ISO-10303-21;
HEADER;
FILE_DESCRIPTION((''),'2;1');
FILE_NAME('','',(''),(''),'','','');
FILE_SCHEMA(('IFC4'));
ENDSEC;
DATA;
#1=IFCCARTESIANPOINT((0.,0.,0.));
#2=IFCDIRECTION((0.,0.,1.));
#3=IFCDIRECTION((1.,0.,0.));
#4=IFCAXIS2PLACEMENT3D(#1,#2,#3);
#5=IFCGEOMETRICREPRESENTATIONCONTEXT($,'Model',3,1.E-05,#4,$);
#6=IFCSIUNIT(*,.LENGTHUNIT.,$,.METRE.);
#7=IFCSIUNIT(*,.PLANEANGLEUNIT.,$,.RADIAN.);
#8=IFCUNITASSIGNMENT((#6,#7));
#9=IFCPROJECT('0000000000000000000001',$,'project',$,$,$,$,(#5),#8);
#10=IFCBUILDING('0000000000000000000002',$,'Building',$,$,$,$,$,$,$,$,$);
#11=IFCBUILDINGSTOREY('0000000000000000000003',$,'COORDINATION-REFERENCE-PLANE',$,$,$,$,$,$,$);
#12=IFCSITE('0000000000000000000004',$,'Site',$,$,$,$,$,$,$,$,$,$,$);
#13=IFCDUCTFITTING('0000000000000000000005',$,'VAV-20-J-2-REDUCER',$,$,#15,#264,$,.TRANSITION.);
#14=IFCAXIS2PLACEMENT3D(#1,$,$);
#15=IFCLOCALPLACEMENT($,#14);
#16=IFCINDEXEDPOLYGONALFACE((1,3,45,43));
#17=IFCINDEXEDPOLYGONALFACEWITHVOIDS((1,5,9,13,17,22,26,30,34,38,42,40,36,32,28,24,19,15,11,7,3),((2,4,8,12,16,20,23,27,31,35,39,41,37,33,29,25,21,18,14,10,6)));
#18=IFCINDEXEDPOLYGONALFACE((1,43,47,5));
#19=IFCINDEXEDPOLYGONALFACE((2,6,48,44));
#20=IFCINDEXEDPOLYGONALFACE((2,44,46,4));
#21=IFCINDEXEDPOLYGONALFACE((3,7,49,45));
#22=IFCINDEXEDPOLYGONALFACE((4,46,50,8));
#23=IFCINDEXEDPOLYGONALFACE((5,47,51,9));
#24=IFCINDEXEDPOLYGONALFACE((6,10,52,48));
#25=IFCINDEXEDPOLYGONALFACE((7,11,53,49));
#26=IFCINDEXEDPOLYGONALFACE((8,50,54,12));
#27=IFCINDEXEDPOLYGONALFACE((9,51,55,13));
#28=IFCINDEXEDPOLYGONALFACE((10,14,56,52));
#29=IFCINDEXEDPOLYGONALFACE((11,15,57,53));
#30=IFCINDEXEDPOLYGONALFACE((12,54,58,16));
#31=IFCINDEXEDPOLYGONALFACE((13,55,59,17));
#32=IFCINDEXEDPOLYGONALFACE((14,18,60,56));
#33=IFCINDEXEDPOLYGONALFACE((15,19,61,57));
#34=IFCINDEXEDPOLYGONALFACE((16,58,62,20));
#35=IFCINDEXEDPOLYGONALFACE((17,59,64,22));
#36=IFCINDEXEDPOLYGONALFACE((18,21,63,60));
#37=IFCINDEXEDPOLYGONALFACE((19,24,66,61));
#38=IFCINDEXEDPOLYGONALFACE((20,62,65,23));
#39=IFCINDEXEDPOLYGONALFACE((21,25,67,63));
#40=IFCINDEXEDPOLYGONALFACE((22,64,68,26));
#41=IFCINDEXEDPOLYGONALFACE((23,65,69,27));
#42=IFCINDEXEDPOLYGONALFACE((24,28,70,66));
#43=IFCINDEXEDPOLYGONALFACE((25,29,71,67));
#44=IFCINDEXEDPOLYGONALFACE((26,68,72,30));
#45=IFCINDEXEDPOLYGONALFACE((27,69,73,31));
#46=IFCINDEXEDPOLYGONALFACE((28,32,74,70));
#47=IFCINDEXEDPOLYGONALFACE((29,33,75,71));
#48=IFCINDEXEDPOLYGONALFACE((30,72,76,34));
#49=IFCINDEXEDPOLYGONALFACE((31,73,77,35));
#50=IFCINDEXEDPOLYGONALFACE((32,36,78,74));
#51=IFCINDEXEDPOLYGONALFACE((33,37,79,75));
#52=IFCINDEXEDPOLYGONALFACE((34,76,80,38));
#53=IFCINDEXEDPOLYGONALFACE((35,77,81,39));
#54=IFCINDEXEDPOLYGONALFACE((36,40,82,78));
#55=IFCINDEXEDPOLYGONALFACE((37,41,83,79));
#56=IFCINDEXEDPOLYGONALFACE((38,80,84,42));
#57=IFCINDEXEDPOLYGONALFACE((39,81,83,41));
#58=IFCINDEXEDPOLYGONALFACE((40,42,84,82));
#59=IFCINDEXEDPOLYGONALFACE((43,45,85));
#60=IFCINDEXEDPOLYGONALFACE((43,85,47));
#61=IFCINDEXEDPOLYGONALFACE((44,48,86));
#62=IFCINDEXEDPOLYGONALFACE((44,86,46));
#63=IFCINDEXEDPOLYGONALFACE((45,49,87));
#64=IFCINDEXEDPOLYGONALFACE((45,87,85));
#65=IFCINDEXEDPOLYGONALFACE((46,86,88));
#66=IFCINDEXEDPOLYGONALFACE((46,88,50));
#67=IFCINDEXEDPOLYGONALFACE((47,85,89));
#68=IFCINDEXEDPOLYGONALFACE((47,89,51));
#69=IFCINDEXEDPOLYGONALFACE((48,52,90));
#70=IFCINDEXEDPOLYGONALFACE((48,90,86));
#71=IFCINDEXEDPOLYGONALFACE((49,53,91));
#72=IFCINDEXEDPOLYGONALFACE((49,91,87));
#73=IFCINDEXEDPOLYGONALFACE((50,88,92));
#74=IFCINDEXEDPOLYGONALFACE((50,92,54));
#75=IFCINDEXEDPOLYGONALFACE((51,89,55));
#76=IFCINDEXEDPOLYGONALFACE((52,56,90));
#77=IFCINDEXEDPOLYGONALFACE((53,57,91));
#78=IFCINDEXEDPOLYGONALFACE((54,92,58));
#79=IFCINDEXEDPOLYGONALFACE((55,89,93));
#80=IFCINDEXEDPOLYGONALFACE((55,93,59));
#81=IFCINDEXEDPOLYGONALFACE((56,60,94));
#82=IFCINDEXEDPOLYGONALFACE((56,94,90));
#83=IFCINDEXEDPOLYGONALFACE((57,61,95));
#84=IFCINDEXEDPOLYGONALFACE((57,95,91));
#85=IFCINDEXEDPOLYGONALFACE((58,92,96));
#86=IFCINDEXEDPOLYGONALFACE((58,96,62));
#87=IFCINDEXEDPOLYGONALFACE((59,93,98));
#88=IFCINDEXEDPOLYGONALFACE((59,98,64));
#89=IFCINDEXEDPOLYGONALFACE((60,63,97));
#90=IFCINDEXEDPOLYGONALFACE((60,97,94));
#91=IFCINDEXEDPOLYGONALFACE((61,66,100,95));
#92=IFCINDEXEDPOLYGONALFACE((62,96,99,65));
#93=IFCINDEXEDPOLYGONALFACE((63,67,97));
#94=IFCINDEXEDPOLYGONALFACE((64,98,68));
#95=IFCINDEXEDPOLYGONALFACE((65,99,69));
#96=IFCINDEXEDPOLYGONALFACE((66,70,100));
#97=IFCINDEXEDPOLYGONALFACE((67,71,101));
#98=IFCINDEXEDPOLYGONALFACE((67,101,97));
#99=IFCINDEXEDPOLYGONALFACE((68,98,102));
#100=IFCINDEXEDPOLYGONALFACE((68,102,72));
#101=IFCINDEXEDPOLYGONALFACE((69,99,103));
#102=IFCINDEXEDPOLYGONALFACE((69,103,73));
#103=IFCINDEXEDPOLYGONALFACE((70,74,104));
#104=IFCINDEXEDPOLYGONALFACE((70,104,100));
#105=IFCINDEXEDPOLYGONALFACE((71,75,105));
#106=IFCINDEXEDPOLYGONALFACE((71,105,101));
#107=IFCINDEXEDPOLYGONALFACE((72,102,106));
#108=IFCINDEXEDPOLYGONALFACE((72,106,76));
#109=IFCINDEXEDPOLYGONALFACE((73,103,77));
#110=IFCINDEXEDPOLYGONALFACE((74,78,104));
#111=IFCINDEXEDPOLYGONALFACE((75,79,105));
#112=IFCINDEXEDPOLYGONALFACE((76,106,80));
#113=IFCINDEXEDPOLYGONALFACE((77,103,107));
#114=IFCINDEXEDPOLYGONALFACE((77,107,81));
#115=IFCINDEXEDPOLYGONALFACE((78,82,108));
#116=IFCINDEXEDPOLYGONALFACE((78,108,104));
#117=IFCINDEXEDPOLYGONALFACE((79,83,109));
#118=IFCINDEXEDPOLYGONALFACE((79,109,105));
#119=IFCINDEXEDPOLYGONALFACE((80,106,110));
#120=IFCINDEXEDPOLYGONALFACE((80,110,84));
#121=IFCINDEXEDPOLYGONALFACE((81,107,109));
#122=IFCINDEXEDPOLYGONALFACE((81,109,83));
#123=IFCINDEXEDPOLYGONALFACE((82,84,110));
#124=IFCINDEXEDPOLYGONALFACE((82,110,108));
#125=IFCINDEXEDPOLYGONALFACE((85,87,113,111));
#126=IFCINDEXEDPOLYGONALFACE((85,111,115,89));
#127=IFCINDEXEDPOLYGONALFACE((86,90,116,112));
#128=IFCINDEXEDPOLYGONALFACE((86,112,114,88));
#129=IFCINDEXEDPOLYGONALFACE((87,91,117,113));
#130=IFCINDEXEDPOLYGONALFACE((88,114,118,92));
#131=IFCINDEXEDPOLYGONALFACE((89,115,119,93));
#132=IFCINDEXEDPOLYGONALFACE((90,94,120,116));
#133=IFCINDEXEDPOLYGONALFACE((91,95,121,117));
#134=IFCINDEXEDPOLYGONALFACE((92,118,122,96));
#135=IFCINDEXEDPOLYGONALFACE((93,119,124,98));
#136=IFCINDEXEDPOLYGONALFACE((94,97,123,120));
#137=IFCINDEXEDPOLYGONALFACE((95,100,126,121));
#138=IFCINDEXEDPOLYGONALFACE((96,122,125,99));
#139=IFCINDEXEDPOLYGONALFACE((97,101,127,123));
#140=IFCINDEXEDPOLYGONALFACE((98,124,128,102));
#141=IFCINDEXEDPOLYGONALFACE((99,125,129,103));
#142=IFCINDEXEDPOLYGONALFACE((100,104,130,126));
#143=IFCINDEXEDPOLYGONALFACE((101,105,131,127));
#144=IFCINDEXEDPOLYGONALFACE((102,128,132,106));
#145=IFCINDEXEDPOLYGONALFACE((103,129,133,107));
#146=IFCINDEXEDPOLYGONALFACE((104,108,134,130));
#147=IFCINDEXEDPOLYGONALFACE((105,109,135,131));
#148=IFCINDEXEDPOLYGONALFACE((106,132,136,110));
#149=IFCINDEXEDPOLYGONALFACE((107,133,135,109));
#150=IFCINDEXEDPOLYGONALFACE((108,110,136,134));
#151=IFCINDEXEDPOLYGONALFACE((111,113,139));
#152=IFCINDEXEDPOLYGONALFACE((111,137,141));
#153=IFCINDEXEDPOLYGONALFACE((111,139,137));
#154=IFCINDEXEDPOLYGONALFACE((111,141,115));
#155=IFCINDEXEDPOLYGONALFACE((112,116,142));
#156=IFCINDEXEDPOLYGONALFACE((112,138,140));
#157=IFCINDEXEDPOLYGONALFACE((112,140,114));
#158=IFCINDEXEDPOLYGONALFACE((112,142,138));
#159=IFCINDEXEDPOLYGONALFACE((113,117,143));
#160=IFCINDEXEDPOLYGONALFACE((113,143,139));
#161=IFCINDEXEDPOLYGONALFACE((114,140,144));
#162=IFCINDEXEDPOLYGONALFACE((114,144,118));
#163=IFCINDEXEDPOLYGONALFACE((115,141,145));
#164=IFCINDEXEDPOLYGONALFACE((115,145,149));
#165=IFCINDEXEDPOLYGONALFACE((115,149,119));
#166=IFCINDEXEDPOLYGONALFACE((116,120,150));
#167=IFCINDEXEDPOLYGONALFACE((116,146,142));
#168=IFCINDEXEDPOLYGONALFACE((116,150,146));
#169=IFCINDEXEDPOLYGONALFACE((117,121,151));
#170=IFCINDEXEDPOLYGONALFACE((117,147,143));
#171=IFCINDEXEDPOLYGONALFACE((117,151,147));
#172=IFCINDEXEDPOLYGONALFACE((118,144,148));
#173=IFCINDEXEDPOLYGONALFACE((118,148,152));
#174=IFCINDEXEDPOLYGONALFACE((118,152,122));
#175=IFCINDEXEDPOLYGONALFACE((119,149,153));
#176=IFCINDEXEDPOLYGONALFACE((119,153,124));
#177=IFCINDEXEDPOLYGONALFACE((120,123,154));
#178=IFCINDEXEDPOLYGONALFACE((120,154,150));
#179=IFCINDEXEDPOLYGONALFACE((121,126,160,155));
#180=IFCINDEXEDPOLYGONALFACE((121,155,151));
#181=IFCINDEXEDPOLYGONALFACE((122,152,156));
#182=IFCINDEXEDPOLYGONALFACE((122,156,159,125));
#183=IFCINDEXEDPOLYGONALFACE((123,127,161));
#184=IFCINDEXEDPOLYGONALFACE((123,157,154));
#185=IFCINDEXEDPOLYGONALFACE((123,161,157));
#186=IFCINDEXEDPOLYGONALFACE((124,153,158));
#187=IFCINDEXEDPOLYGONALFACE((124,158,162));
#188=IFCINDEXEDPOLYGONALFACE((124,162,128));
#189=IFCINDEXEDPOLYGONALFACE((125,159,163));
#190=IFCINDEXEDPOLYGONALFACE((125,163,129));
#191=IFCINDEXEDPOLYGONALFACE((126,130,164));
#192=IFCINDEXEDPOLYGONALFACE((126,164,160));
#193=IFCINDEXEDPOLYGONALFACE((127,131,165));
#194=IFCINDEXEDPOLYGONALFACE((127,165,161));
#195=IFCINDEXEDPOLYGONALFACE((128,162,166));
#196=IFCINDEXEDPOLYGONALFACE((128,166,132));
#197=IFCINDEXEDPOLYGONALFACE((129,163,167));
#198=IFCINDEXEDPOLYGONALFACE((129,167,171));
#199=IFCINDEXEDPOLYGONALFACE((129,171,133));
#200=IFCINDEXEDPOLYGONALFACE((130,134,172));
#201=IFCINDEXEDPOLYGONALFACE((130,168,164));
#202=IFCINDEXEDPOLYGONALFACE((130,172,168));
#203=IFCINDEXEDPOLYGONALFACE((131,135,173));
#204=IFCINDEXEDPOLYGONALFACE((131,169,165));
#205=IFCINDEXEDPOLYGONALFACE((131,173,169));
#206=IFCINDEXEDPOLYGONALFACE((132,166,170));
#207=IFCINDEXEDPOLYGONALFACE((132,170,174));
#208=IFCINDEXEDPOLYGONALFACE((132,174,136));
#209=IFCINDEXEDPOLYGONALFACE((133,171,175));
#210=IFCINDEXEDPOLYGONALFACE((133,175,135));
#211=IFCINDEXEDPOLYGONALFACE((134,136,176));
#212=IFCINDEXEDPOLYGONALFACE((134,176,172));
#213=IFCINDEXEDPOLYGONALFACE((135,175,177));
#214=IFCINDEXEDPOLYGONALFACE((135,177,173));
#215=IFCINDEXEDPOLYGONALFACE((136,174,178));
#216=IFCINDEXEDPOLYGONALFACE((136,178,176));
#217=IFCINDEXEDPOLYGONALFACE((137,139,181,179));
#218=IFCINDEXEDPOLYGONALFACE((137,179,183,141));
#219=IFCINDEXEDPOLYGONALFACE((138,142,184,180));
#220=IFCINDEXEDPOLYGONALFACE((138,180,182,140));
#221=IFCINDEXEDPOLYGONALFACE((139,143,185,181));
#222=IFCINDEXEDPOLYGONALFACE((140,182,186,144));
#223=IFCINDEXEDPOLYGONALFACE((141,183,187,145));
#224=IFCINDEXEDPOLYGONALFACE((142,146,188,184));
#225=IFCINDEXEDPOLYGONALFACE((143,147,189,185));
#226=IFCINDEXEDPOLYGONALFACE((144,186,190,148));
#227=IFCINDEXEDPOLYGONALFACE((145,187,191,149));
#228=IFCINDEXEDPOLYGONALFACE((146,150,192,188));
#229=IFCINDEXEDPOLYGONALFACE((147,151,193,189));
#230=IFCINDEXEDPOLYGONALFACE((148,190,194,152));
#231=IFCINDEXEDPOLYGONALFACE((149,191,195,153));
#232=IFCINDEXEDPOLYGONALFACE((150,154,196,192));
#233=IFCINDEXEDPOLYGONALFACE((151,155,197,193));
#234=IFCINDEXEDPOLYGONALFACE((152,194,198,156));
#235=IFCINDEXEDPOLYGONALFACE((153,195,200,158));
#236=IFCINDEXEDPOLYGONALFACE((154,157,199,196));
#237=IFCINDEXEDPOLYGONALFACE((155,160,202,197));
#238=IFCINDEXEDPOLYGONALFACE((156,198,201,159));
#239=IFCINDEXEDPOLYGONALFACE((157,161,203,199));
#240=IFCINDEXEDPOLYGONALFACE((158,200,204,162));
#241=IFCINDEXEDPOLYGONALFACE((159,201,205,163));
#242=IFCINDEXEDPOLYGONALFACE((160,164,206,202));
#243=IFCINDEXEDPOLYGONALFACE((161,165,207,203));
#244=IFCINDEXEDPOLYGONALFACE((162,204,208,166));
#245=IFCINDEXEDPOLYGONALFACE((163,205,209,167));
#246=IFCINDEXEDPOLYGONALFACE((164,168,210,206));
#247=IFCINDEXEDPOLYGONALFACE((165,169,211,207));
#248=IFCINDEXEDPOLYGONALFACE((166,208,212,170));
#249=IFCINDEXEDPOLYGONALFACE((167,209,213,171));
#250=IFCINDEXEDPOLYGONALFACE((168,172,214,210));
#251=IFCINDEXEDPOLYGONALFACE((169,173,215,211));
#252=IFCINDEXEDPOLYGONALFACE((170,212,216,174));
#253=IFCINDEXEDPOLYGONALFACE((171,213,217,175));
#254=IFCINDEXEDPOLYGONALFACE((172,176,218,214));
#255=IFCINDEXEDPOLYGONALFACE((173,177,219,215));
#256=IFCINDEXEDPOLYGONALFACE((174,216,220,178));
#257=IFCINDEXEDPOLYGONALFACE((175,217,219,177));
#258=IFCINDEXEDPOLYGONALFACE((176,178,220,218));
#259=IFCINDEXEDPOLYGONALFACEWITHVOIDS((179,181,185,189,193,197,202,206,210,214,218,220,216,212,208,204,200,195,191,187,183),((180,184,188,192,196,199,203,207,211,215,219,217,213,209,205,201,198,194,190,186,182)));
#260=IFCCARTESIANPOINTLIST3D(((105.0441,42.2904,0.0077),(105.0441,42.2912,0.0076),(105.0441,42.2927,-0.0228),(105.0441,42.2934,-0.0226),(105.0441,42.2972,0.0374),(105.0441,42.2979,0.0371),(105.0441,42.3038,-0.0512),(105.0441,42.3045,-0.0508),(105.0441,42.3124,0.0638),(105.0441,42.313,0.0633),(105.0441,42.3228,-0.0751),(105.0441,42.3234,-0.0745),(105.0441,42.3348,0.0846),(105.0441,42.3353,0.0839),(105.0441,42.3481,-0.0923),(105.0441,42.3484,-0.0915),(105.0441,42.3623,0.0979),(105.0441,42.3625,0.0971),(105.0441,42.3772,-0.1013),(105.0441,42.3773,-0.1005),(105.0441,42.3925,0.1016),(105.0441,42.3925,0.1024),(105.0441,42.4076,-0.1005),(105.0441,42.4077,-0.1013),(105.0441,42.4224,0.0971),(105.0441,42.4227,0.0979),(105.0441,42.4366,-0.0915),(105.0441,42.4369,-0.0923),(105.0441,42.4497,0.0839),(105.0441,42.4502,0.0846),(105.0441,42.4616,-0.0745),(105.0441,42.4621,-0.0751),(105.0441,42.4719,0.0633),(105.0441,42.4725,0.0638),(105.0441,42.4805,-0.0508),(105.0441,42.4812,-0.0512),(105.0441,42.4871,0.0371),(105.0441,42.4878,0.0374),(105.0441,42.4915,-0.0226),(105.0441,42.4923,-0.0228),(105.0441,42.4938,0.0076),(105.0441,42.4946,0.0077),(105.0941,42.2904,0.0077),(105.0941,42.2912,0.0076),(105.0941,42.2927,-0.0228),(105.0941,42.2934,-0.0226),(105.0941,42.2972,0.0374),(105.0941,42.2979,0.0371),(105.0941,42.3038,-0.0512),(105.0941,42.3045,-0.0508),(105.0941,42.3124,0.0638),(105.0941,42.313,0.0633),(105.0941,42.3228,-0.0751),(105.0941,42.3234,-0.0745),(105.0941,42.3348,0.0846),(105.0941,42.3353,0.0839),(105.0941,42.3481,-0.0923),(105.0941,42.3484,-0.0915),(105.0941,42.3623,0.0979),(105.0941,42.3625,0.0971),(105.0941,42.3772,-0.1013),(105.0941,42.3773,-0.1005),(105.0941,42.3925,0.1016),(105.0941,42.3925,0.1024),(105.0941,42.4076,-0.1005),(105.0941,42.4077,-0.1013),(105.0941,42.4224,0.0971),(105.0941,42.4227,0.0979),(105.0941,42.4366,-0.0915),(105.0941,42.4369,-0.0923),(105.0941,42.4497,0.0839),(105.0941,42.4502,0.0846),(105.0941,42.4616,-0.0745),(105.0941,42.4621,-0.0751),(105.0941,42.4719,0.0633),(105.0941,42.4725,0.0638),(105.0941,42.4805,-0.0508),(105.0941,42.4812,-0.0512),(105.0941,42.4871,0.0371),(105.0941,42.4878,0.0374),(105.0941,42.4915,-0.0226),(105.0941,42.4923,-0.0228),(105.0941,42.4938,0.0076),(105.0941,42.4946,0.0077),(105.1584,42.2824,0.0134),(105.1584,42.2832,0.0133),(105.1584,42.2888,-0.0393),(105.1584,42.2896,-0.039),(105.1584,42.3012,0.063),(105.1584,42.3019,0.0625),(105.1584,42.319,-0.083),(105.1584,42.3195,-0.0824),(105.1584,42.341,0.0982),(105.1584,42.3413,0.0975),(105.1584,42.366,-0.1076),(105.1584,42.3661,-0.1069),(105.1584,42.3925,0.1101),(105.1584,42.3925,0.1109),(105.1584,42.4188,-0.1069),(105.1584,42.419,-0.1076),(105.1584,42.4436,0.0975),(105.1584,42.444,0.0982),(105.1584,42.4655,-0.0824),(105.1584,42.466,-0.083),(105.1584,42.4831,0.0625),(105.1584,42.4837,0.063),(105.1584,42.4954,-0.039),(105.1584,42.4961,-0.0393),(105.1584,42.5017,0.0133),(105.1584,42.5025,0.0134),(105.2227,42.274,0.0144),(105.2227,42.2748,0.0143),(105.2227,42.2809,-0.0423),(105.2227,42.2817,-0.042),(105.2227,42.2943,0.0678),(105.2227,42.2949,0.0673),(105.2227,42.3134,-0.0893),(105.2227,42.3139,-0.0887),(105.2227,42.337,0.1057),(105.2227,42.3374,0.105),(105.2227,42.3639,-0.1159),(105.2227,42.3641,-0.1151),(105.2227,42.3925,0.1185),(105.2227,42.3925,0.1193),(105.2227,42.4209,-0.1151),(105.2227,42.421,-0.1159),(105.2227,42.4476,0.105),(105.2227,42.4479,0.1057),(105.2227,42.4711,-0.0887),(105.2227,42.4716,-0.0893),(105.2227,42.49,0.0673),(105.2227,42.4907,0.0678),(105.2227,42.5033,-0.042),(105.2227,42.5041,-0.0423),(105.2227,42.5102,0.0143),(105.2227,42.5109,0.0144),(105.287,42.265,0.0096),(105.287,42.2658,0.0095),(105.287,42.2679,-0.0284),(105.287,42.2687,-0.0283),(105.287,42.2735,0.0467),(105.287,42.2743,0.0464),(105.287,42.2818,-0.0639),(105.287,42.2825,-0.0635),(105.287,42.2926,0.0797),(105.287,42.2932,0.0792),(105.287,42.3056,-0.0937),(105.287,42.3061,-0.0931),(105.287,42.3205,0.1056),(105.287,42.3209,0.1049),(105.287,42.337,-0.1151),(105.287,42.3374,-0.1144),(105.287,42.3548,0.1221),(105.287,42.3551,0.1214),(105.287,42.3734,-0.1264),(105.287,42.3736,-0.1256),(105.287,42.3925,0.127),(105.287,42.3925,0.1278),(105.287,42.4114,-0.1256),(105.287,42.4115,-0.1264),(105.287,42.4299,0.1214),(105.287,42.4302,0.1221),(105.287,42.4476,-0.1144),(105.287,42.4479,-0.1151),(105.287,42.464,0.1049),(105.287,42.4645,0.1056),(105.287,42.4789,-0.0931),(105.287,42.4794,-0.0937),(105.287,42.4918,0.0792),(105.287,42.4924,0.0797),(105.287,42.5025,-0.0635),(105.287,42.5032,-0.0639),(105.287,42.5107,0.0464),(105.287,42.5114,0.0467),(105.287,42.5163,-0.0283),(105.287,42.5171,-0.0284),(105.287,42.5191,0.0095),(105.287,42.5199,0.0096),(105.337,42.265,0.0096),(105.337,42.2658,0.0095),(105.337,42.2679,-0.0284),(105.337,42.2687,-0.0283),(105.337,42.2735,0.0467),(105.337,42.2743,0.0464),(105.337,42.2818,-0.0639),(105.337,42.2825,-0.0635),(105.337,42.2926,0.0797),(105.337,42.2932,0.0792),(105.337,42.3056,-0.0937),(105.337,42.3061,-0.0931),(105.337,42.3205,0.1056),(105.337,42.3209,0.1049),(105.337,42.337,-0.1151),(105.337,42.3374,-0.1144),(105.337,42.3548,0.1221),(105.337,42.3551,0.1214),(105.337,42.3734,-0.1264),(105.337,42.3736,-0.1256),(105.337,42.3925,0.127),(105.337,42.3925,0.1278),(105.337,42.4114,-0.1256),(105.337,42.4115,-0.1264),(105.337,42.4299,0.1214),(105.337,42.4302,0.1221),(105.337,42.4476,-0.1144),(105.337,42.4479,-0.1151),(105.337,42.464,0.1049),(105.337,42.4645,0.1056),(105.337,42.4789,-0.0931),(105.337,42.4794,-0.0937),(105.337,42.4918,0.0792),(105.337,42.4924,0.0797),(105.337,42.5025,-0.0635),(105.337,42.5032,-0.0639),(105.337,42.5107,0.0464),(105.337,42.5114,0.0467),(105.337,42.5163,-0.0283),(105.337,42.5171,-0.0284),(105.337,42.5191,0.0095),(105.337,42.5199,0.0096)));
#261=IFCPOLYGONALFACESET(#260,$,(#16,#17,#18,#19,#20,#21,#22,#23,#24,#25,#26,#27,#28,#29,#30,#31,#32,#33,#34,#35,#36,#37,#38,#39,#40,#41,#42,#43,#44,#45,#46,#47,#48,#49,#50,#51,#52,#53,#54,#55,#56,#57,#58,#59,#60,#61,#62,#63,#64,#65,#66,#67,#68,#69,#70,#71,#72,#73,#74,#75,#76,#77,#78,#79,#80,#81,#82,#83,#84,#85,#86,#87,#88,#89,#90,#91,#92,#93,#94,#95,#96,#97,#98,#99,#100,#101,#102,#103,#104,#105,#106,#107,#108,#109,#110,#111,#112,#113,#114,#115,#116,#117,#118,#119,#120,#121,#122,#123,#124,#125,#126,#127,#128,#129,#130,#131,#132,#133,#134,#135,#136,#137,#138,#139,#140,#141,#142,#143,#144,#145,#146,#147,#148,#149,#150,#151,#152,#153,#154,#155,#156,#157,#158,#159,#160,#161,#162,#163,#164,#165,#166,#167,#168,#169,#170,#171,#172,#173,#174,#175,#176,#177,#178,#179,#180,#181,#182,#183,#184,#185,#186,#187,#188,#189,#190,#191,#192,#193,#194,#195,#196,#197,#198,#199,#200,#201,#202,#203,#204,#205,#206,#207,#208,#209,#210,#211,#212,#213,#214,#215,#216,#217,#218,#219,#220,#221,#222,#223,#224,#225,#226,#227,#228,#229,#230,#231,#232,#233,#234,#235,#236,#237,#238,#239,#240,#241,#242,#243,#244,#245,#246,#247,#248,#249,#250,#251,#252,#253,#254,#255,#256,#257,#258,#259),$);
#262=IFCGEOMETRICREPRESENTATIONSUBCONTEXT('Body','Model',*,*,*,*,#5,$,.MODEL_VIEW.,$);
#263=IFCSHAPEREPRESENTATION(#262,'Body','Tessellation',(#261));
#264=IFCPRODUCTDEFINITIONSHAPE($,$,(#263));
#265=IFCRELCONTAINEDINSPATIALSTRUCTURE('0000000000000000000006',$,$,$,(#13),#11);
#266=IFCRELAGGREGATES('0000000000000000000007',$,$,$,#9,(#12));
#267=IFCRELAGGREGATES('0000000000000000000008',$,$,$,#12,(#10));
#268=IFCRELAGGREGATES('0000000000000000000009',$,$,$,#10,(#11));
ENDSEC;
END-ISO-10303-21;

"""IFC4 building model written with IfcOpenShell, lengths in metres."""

from ifc_helpers import new_model, entity, si_unit, frame, origin_with_axes, place, context, subcontext, project, spatial, element, save


model = new_model("IFC4")

# Units and contexts
model_context_1 = context("Model", 3, precision=1e-05, world=origin_with_axes())
body_context_1 = subcontext(model_context_1, "Body", "Model", "MODEL_VIEW")
ifc_project = project(units=[si_unit("LENGTHUNIT", "METRE"), si_unit("PLANEANGLEUNIT", "RADIAN")], contexts=[model_context_1])

# Site, building, storey
site = spatial("IfcSite", under=ifc_project, Name="Site")
building = spatial("IfcBuilding", under=site, Name="Building")
storey = spatial("IfcBuildingStorey", under=building, Name="COORDINATION-REFERENCE-PLANE")

# Duct fitting
for number, where, z_axis, x_axis, name in (
    (1, (105.337, 42.3925, 0.0), (0.0, -1.0, 0.0), (0.0, 0.0, 1.0), "VAV-20-J-2-REDUCER"),
):
    element("IfcDuctFitting", number, at=place(None, frame(where, z_axis=z_axis, x_axis=x_axis)), inside=storey, Name=name, PredefinedType="TRANSITION", context=body_context_1, shape_type="SweptSolid", body=[
        entity("IfcRevolvedAreaSolid", entity("IfcArbitraryClosedProfileDef", "AREA", None, entity("IfcPolyline", [entity("IfcCartesianPoint", [0.1278, 0.0]), entity("IfcCartesianPoint", [0.1278, 0.05]), entity("IfcCartesianPoint", [0.1024, 0.2429]), entity("IfcCartesianPoint", [0.1024, 0.2929]), entity("IfcCartesianPoint", [0.1016, 0.2929]), entity("IfcCartesianPoint", [0.1016, 0.2429]), entity("IfcCartesianPoint", [0.127, 0.05]), entity("IfcCartesianPoint", [0.127, 0.0]), entity("IfcCartesianPoint", [0.1278, 0.0])])), entity("IfcAxis2Placement3D", entity("IfcCartesianPoint", [0.0, 0.0, 0.0])), entity("IfcAxis1Placement", entity("IfcCartesianPoint", [0.0, 0.0, 0.0]), entity("IfcDirection", [0.0, 1.0, 0.0])), 6.283185),
    ])

save(model, "model.ifc")
